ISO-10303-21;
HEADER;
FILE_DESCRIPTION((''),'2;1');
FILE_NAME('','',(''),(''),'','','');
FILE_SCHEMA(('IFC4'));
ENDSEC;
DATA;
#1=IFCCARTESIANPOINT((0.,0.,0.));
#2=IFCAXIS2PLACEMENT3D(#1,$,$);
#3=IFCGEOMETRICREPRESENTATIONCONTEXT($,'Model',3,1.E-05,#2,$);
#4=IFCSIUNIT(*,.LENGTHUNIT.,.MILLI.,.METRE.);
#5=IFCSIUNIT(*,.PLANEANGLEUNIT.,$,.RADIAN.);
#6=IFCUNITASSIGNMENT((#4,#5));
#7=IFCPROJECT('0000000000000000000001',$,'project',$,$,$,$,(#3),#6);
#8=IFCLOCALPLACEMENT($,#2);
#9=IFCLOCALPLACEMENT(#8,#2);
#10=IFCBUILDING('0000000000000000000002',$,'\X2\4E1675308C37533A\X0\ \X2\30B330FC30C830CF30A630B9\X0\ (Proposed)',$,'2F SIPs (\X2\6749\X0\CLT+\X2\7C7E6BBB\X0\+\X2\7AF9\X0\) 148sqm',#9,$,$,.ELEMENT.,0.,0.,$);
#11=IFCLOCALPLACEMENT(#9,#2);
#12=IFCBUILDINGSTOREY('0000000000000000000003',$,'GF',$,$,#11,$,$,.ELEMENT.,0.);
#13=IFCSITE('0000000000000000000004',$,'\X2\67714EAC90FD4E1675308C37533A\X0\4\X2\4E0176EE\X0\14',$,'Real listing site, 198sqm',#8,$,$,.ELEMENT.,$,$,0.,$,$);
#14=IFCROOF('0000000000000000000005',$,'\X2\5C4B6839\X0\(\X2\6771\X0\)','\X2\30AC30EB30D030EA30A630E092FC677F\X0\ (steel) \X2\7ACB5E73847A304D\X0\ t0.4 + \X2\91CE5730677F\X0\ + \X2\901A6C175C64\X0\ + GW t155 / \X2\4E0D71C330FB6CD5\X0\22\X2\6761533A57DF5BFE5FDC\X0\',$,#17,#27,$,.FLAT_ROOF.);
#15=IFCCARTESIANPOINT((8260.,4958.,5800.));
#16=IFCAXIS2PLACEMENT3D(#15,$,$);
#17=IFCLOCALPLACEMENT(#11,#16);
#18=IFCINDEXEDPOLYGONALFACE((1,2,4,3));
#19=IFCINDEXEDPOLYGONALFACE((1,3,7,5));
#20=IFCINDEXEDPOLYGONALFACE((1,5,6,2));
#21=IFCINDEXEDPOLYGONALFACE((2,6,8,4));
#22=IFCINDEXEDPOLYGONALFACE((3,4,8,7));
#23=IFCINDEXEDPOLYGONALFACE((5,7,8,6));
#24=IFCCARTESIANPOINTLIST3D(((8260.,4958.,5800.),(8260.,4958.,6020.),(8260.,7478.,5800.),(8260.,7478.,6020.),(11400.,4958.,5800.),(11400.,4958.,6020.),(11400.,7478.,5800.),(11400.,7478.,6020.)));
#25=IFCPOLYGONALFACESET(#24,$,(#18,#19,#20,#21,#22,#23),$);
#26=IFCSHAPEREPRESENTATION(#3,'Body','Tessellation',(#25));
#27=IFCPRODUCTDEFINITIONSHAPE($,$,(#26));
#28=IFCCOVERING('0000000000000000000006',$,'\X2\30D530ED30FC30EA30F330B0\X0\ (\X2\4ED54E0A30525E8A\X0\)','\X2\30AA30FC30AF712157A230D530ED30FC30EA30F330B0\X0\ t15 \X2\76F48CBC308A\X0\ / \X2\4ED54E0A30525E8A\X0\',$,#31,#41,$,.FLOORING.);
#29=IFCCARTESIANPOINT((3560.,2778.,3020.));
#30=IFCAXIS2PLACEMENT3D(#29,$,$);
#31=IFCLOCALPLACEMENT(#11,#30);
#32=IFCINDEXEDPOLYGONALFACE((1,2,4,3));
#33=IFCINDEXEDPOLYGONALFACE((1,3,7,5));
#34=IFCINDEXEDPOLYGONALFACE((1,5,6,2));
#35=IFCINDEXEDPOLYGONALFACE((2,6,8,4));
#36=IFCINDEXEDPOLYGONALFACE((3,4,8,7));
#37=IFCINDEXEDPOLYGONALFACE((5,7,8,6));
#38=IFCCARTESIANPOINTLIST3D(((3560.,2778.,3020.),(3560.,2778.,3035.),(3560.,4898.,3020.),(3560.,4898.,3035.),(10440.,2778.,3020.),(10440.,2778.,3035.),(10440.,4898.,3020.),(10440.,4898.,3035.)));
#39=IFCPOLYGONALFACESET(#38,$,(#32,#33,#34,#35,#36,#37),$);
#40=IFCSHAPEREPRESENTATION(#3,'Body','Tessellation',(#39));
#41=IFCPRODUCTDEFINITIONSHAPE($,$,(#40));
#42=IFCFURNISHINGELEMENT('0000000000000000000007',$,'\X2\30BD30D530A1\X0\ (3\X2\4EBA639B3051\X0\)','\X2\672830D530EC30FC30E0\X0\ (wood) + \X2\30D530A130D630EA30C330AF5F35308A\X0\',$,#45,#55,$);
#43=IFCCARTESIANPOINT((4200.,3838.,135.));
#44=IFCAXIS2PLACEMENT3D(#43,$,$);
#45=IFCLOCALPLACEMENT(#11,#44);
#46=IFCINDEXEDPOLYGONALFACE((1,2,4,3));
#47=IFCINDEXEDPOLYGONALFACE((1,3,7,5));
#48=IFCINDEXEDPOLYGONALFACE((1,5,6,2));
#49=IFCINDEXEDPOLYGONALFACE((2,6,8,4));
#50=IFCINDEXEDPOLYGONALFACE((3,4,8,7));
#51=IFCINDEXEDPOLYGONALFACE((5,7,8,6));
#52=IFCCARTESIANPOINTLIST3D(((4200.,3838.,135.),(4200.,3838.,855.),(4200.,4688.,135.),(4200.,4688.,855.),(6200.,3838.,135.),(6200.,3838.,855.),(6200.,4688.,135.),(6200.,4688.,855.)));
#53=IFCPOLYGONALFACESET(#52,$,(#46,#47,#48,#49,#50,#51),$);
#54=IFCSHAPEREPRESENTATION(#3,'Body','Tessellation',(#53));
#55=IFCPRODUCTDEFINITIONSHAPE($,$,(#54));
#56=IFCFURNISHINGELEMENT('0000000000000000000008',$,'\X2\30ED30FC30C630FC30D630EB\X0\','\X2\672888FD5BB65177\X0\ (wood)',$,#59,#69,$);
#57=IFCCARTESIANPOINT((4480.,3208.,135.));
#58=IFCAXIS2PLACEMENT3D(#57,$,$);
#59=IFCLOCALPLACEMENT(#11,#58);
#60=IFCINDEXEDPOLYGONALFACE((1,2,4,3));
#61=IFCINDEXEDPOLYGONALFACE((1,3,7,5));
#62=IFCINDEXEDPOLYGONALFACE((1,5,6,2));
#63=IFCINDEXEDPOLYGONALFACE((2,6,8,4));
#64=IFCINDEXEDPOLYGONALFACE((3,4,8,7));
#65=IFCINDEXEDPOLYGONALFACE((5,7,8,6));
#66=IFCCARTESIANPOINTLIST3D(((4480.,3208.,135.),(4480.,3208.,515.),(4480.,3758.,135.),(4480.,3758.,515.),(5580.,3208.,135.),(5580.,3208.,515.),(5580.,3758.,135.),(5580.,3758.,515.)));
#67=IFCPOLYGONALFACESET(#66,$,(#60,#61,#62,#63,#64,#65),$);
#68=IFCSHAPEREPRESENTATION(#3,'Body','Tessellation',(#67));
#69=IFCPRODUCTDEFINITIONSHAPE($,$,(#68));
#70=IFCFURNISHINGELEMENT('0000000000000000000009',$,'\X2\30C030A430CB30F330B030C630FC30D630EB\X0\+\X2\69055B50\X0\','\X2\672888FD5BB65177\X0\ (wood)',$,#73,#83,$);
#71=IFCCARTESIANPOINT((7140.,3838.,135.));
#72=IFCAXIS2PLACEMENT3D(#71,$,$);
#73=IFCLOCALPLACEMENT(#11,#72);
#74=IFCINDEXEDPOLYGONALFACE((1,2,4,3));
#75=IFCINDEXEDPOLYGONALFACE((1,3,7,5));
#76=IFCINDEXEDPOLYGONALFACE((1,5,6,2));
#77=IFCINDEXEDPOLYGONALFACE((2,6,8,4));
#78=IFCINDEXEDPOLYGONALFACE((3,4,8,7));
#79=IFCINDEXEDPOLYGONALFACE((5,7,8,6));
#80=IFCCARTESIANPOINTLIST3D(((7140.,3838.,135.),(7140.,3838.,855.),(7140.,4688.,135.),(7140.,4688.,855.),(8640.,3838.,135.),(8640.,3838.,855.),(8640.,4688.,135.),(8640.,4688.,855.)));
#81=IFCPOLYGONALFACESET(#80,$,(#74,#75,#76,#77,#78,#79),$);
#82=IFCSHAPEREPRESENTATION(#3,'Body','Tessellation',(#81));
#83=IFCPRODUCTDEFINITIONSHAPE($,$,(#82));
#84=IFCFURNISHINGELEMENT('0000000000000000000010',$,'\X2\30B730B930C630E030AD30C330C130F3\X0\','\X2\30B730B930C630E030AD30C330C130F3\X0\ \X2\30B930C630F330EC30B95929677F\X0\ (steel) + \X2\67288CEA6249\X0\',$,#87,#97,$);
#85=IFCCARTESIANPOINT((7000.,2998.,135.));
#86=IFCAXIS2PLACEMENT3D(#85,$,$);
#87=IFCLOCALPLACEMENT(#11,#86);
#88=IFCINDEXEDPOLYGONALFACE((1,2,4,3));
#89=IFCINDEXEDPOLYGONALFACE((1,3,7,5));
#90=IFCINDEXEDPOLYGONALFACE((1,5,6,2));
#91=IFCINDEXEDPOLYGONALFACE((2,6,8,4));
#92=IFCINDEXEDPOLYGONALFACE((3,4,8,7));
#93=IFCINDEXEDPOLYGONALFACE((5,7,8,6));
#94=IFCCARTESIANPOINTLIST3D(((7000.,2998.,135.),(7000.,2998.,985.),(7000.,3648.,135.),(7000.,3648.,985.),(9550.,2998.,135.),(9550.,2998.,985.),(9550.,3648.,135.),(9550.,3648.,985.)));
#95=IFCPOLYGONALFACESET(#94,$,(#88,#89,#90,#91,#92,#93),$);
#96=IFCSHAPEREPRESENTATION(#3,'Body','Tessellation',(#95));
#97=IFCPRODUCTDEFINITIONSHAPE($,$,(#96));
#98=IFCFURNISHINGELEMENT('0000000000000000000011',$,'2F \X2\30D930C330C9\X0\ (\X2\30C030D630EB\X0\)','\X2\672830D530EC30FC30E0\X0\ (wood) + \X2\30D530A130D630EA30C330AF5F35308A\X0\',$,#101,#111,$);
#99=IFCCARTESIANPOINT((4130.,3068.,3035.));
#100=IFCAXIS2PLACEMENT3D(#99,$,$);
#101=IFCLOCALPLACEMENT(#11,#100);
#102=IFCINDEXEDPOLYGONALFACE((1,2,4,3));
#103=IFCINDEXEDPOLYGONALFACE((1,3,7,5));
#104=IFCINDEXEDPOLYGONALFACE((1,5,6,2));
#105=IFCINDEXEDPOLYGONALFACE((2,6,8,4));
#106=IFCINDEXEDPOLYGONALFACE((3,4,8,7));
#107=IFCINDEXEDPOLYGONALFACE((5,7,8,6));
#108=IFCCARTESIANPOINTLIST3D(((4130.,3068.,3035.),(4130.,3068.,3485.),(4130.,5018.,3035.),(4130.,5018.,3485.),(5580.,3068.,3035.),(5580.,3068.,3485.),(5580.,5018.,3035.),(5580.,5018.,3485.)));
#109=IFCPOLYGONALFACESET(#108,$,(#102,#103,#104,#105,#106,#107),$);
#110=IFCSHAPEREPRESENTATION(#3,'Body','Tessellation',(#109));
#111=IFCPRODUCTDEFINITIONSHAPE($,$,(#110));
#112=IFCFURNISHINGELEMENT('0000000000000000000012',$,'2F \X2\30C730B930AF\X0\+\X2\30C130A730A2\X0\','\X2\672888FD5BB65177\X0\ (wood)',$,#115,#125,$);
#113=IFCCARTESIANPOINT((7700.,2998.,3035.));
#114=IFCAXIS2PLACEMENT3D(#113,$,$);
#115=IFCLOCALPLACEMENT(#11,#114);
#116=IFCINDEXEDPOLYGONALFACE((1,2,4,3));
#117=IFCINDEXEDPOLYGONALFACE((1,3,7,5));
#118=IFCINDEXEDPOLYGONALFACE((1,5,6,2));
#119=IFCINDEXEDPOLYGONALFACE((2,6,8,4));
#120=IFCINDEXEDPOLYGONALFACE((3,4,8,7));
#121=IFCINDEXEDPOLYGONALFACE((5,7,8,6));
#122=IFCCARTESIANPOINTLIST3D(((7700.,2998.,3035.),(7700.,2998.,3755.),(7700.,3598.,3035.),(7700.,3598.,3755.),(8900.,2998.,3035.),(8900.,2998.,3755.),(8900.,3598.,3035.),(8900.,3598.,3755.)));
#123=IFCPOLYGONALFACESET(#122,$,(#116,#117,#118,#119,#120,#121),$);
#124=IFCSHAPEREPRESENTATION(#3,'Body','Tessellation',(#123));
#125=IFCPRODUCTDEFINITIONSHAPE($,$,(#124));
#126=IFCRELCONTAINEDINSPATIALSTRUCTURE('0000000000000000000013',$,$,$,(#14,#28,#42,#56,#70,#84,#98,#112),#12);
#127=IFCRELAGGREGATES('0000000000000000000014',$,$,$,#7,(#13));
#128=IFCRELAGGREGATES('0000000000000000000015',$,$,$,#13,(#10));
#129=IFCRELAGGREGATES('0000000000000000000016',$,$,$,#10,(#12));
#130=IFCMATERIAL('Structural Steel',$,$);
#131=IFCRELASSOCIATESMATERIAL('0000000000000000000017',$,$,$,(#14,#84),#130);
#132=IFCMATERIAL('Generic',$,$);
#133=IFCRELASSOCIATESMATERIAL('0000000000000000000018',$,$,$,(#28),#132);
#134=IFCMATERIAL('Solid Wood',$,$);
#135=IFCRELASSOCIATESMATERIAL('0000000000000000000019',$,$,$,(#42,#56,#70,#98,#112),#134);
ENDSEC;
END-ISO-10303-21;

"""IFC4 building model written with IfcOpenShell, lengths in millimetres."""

from ifc_helpers import new_model, si_unit, frame, frame_2d, origin, place, context, project, spatial, rectangle, extrude, material, element, save


model = new_model("IFC4")

# Units and contexts
model_context = context("Model", 3, precision=1e-05, world=origin())
ifc_project = project(units=[si_unit("LENGTHUNIT", "METRE", prefix="MILLI"), si_unit("PLANEANGLEUNIT", "RADIAN")], contexts=[model_context])

# Site, building, storey
site_placement = place(None, origin())
site = spatial("IfcSite", under=ifc_project, at=site_placement, Name="東京都世田谷区4丁目14", ObjectType="Real listing site, 198sqm", CompositionType="ELEMENT", RefElevation=0.0)
building_placement = place(site_placement, origin())
building = spatial("IfcBuilding", under=site, at=building_placement, Name="世田谷区 コートハウス (Proposed)", ObjectType="2F SIPs (杉CLT+籾殻+竹) 148sqm", CompositionType="ELEMENT", ElevationOfRefHeight=0.0, ElevationOfTerrain=0.0)
storey_placement = place(building_placement, origin())
storey = spatial("IfcBuildingStorey", under=building, at=storey_placement, Name="GF", CompositionType="ELEMENT", Elevation=0.0)

# Shared definitions
ifc_material_1 = material(Name="Solid Wood")

# Shared definitions
ifc_material_2 = material(Name="Generic")

# Roof
ifc_material_3 = material(Name="Structural Steel")
roof_placement = place(storey_placement, frame((8260.0, 4958.0, 5800.0)))
element("IfcRoof", 1, at=roof_placement, inside=storey, material=ifc_material_3, Name="屋根(東)", Description="ガルバリウム鋼板 (steel) 立平葺き t0.4 + 野地板 + 通気層 + GW t155 / 不燃・法22条区域対応", PredefinedType="FLAT_ROOF", context=model_context, shape_type="SweptSolid", body=[
    extrude(rectangle(XDim=3140.0, YDim=2520.0, at=frame_2d((1570.0, 1260.0))), frame((8260.0, 4958.0, 5800.0)), (0.0, 0.0, 1.0), 220.0),
])

# Covering
covering_placement = place(storey_placement, frame((3560.0, 2778.0, 3020.0)))
element("IfcCovering", 2, at=covering_placement, inside=storey, material=ifc_material_2, Name="フローリング (仕上げ床)", Description="オーク無垢フローリング t15 直貼り / 仕上げ床", PredefinedType="FLOORING", context=model_context, shape_type="SweptSolid", body=[
    extrude(rectangle(XDim=6880.0, YDim=2120.0, at=frame_2d((3440.0, 1060.0))), frame((3560.0, 2778.0, 3020.0)), (0.0, 0.0, 1.0), 15.0),
])

# Furnishing elements
furnishing_1_placement = place(storey_placement, frame((4200.0, 3838.0, 135.0)))
element("IfcFurnishingElement", 3, at=furnishing_1_placement, inside=storey, material=ifc_material_1, Name="ソファ (3人掛け)", Description="木フレーム (wood) + ファブリック張り", context=model_context, shape_type="SweptSolid", body=[
    extrude(rectangle(XDim=2000.0, YDim=850.0, at=frame_2d((1000.0, 425.0))), frame((4200.0, 3838.0, 135.0)), (0.0, 0.0, 1.0), 720.0),
])
furnishing_2_placement = place(storey_placement, frame((4480.0, 3208.0, 135.0)))
element("IfcFurnishingElement", 4, at=furnishing_2_placement, inside=storey, material=ifc_material_1, Name="ローテーブル", Description="木製家具 (wood)", context=model_context, shape_type="SweptSolid", body=[
    extrude(rectangle(XDim=1100.0, YDim=550.0, at=frame_2d((550.0, 275.0))), frame((4480.0, 3208.0, 135.0)), (0.0, 0.0, 1.0), 380.0),
])
furnishing_3_placement = place(storey_placement, frame((7140.0, 3838.0, 135.0)))
element("IfcFurnishingElement", 5, at=furnishing_3_placement, inside=storey, material=ifc_material_1, Name="ダイニングテーブル+椅子", Description="木製家具 (wood)", context=model_context, shape_type="SweptSolid", body=[
    extrude(rectangle(XDim=1500.0, YDim=850.0, at=frame_2d((750.0, 425.0))), frame((7140.0, 3838.0, 135.0)), (0.0, 0.0, 1.0), 720.0),
])
furnishing_4_placement = place(storey_placement, frame((7000.0, 2998.0, 135.0)))
element("IfcFurnishingElement", 6, at=furnishing_4_placement, inside=storey, material=ifc_material_3, Name="システムキッチン", Description="システムキッチン ステンレス天板 (steel) + 木質扉", context=model_context, shape_type="SweptSolid", body=[
    extrude(rectangle(XDim=2550.0, YDim=650.0, at=frame_2d((1275.0, 325.0))), frame((7000.0, 2998.0, 135.0)), (0.0, 0.0, 1.0), 850.0),
])
furnishing_5_placement = place(storey_placement, frame((4130.0, 3068.0, 3035.0)))
element("IfcFurnishingElement", 7, at=furnishing_5_placement, inside=storey, material=ifc_material_1, Name="2F ベッド (ダブル)", Description="木フレーム (wood) + ファブリック張り", context=model_context, shape_type="SweptSolid", body=[
    extrude(rectangle(XDim=1450.0, YDim=1950.0, at=frame_2d((725.0, 975.0))), frame((4130.0, 3068.0, 3035.0)), (0.0, 0.0, 1.0), 450.0),
])
furnishing_6_placement = place(storey_placement, frame((7700.0, 2998.0, 3035.0)))
element("IfcFurnishingElement", 8, at=furnishing_6_placement, inside=storey, material=ifc_material_1, Name="2F デスク+チェア", Description="木製家具 (wood)", context=model_context, shape_type="SweptSolid", body=[
    extrude(rectangle(XDim=1200.0, YDim=600.0, at=frame_2d((600.0, 300.0))), frame((7700.0, 2998.0, 3035.0)), (0.0, 0.0, 1.0), 720.0),
])

save(model, "model.ifc")
